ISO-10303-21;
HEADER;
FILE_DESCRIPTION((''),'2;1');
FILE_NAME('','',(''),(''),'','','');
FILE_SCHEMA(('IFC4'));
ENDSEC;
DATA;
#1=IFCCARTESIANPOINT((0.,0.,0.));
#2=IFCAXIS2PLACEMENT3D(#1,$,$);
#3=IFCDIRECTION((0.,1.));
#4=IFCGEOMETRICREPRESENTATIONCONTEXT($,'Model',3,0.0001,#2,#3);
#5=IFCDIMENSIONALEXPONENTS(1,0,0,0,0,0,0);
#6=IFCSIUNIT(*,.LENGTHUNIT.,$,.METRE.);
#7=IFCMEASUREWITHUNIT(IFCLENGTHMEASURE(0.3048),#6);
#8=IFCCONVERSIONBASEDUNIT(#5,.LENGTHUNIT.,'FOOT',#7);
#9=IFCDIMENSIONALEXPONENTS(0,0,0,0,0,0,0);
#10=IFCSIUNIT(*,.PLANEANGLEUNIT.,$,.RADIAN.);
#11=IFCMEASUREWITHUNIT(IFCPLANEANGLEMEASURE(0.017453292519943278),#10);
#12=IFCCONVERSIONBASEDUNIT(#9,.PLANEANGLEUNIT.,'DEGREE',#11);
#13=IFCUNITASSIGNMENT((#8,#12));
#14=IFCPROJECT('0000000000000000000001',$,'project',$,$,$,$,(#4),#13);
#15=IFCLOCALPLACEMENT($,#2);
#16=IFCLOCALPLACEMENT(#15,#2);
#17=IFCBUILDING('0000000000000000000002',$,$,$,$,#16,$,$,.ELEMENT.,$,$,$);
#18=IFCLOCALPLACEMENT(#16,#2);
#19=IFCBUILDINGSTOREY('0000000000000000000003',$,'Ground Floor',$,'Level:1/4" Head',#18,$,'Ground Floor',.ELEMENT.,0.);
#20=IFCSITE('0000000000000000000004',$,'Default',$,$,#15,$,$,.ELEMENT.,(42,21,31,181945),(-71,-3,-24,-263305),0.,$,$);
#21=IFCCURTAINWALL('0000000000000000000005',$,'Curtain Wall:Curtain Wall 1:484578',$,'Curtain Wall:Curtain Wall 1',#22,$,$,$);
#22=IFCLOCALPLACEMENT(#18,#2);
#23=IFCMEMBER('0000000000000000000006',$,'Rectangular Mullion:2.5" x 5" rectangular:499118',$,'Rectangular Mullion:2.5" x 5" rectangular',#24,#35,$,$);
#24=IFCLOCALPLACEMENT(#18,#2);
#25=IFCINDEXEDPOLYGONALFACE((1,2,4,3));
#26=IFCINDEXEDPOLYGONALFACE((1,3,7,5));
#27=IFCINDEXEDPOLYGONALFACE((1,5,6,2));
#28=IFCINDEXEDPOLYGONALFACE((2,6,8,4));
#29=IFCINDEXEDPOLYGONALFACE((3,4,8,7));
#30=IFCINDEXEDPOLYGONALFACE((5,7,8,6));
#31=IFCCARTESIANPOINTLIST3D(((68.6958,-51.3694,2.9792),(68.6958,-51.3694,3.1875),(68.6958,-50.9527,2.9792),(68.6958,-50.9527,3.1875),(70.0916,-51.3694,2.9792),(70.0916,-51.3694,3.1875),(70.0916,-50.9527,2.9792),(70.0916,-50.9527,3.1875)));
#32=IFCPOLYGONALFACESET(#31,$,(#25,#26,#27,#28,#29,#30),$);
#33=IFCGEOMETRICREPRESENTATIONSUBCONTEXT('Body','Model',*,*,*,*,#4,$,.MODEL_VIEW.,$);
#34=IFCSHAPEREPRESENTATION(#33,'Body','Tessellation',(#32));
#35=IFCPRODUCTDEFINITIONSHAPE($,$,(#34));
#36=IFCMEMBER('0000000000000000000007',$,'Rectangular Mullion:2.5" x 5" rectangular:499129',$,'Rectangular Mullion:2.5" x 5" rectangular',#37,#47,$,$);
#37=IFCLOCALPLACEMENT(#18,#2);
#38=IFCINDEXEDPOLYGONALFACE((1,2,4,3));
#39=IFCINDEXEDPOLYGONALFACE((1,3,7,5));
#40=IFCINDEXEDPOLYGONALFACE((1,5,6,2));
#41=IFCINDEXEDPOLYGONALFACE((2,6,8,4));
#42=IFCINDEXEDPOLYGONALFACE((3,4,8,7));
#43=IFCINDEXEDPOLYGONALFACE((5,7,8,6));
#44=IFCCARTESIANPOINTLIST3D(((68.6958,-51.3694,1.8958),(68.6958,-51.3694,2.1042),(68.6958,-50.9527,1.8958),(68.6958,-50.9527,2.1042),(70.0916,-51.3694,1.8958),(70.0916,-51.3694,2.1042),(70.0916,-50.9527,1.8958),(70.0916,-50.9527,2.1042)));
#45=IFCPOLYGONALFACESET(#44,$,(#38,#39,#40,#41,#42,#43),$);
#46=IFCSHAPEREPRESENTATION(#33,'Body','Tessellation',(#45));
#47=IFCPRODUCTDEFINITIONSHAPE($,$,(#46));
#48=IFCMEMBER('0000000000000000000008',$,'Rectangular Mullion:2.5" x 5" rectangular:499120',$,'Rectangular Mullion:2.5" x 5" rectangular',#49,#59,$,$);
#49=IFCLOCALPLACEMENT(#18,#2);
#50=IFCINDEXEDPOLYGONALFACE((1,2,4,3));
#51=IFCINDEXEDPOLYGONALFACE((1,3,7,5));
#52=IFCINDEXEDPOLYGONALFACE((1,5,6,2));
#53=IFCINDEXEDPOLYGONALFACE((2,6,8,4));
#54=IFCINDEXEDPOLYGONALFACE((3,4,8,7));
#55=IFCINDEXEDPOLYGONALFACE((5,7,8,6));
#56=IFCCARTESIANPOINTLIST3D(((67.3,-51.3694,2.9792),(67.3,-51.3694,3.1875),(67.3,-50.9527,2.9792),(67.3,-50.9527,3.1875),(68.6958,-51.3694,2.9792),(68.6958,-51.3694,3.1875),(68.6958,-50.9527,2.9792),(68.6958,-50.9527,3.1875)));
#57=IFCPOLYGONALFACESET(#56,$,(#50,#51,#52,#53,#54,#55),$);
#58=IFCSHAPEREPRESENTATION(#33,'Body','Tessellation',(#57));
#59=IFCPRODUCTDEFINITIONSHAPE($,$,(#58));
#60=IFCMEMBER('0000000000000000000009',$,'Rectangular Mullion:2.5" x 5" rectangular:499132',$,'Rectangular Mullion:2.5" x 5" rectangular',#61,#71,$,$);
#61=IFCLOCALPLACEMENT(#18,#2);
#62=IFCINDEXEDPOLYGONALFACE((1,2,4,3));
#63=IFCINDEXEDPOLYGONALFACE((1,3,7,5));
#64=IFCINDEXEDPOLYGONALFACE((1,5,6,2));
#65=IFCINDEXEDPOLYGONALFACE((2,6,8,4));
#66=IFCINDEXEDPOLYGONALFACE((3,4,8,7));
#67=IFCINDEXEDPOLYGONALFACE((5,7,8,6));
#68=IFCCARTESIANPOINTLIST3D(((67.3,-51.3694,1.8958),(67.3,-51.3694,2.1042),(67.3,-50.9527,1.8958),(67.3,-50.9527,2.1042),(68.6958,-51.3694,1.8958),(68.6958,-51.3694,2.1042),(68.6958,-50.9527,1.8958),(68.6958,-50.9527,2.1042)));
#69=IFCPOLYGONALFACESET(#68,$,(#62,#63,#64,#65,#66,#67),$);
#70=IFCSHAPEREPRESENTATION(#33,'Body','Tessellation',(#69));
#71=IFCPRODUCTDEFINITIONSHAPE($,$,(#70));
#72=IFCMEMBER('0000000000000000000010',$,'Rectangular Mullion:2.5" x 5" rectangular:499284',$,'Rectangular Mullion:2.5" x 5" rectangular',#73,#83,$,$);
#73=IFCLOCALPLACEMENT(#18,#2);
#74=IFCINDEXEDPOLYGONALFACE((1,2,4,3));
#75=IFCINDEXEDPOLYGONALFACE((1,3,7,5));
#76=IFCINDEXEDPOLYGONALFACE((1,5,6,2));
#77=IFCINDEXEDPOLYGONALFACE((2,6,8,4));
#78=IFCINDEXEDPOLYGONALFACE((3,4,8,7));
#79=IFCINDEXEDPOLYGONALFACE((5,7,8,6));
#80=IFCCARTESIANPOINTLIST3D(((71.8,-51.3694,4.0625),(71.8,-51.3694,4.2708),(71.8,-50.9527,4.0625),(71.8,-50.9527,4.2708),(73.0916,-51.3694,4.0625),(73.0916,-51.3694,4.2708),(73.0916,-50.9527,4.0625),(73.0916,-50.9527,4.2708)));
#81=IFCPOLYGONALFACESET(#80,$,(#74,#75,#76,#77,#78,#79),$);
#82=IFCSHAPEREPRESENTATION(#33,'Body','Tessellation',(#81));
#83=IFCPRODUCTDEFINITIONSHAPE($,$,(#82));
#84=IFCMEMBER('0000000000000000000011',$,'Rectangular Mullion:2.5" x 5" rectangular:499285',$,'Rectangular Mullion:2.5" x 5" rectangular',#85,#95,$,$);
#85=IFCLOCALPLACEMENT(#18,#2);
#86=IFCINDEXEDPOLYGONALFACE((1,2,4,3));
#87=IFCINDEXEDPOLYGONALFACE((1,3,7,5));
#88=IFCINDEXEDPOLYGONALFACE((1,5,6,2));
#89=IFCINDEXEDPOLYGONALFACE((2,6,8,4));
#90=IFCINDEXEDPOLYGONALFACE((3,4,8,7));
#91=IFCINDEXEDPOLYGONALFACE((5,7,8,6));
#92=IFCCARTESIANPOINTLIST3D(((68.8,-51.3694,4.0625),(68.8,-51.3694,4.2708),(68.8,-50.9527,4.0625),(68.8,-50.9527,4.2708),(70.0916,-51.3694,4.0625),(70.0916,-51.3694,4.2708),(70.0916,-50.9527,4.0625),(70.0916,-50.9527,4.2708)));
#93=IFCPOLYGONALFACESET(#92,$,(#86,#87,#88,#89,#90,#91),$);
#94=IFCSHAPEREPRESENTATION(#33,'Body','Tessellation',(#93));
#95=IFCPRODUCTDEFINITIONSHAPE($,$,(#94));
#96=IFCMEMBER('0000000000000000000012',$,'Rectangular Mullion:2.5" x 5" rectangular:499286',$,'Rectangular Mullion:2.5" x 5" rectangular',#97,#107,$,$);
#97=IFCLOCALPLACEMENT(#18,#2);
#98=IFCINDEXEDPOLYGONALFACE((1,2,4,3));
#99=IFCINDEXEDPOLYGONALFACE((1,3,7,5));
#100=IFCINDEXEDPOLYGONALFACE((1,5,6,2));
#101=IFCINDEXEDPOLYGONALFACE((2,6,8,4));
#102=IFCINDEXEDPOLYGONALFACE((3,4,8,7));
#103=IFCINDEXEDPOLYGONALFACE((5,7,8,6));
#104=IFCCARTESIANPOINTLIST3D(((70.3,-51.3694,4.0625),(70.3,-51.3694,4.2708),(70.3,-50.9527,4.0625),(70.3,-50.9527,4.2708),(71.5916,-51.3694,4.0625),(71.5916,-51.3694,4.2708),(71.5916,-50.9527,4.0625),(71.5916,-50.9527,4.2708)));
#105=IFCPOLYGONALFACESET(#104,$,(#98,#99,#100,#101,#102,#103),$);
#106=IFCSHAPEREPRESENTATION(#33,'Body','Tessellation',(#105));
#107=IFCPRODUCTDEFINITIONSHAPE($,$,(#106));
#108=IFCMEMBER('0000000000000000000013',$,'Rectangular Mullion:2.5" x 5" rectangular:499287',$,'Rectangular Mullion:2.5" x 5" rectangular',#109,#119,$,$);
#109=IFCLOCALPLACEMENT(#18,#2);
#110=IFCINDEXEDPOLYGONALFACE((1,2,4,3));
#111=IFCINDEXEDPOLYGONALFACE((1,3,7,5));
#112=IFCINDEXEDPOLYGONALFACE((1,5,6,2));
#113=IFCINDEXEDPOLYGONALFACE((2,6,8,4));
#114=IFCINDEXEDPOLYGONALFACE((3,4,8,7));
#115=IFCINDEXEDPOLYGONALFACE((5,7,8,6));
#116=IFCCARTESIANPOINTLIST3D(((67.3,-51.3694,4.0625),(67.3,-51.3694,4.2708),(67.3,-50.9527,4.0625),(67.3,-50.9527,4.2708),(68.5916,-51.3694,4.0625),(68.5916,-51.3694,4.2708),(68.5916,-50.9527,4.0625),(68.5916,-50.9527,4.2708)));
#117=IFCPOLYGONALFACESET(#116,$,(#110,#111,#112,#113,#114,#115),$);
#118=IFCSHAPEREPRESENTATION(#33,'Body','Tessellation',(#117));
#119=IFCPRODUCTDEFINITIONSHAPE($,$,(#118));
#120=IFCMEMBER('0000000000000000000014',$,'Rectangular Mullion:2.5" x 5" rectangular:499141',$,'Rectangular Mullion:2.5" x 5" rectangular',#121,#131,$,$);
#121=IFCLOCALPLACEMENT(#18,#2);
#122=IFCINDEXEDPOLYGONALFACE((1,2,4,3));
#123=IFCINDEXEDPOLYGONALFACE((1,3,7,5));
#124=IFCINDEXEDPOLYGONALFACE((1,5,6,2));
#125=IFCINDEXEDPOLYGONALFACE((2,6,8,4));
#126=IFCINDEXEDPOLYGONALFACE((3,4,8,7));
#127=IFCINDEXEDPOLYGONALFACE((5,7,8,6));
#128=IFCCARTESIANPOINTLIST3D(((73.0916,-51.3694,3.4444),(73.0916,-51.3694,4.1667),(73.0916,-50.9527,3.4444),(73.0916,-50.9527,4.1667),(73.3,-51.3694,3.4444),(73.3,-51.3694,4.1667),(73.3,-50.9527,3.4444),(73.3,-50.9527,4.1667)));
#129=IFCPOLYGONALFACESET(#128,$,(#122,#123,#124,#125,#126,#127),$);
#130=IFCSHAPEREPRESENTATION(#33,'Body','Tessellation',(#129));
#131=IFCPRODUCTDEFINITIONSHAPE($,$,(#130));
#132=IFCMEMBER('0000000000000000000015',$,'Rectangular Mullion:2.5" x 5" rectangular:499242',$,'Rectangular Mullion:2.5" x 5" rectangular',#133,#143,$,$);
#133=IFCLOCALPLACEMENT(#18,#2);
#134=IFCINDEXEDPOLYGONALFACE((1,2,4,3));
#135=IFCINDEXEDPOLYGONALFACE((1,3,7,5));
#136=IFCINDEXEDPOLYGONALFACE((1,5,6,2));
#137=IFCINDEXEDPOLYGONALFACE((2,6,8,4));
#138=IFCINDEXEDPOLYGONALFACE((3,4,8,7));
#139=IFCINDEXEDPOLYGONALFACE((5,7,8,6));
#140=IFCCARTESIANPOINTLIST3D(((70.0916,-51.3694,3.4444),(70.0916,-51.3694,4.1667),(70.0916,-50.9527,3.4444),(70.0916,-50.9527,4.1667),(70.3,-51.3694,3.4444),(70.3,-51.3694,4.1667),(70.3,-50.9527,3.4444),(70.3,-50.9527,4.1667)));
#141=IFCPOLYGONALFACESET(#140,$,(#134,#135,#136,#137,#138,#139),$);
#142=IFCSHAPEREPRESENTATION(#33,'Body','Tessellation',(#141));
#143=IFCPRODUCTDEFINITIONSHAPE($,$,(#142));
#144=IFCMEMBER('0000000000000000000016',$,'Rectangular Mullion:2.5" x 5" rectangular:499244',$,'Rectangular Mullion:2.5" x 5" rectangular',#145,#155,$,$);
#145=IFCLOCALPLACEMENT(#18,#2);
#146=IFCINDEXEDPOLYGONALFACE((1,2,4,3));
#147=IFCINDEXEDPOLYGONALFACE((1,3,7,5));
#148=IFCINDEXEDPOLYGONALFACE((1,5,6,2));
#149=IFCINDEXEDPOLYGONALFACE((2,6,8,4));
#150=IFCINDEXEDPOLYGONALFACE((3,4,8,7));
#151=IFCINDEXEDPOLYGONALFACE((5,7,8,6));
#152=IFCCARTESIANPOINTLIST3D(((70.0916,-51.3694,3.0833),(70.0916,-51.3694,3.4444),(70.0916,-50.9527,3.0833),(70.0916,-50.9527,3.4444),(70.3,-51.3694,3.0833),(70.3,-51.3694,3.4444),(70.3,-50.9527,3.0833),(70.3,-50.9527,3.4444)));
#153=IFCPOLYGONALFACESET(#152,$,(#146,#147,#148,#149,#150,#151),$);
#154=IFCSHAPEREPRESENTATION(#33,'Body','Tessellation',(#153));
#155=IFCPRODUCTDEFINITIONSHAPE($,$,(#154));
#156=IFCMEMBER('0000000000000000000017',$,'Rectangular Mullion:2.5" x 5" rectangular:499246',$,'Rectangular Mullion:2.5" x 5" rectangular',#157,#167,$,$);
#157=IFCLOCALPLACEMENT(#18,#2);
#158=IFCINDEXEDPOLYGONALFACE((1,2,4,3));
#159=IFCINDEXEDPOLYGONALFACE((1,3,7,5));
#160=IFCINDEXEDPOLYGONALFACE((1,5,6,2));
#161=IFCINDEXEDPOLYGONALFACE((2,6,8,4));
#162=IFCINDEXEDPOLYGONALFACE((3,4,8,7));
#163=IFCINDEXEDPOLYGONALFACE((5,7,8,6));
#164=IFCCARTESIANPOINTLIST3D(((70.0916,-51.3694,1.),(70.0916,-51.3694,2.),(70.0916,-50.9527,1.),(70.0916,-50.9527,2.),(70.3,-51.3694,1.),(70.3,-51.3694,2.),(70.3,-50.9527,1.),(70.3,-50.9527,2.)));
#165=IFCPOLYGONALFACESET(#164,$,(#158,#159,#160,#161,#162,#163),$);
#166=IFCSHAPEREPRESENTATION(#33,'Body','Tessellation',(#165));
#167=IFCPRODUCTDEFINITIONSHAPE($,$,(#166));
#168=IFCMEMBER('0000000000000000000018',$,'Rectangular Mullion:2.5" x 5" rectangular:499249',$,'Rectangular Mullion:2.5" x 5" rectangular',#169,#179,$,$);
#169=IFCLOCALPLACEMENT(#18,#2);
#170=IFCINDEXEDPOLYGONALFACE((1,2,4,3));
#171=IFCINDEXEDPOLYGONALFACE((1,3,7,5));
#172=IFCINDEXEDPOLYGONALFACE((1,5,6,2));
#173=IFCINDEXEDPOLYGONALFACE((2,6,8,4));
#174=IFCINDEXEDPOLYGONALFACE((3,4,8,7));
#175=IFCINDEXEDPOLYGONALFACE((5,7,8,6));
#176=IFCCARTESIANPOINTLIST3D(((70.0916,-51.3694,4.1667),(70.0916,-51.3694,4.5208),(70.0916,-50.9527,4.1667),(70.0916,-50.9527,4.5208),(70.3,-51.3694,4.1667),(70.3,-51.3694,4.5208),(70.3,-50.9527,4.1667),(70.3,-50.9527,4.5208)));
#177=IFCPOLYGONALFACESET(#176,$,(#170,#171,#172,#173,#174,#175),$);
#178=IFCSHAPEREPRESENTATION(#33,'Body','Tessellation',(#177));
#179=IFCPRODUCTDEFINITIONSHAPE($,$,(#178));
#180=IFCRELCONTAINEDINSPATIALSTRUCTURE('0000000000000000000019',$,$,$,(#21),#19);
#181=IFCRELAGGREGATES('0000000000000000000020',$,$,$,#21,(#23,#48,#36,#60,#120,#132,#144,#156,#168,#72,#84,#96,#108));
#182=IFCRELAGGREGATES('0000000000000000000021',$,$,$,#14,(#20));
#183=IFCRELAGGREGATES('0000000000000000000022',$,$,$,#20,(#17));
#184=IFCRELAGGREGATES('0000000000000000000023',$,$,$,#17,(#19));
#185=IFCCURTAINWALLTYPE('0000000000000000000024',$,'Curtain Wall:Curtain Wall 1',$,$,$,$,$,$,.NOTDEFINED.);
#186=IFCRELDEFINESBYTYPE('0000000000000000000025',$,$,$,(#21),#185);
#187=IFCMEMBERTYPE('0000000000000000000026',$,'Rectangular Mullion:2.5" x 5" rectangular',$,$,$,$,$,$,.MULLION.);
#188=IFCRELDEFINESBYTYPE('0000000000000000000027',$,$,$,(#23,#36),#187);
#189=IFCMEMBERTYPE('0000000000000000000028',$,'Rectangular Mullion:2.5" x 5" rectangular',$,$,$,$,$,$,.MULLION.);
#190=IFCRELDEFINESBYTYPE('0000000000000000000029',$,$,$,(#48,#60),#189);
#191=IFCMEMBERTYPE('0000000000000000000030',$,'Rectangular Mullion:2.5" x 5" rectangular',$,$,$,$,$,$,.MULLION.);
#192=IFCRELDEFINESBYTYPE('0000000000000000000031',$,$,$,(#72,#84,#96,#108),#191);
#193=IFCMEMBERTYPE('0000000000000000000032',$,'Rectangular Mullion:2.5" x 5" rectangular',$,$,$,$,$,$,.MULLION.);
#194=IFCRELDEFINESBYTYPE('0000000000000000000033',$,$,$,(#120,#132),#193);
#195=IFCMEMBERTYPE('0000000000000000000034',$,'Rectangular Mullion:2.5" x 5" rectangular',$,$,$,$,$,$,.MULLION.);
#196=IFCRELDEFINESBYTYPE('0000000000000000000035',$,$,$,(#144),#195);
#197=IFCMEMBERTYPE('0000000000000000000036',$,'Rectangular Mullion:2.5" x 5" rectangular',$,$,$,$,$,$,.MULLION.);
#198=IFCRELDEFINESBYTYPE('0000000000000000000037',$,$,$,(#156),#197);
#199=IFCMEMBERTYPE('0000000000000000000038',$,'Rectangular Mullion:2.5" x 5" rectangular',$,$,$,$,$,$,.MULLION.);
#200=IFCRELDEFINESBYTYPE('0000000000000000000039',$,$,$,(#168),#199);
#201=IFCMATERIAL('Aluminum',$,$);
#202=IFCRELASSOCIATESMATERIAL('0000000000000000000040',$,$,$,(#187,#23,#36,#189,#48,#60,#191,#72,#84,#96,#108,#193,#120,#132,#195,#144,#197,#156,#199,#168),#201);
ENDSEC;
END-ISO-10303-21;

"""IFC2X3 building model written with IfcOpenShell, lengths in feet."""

from ifc_helpers import new_model, entity, si_unit, converted_unit, direction, frame, origin, origin_2d_with_axis, place, context, subcontext, project, spatial, rectangle, extrude, source, transform, mapped, material, type_object, type_shapes, element, aggregate, save


model = new_model("IFC2X3")

# Units and contexts
model_context = context("Model", 3, precision=0.0001, world=origin(), true_north=direction((0.0, 1.0)))
body_context = subcontext(model_context, "Body", "Model", "MODEL_VIEW")
ifc_project = project(units=[converted_unit("LENGTHUNIT", "FOOT", entity("IfcLengthMeasure", 0.3048), si_unit("LENGTHUNIT", "METRE"), dimensions=[1, 0, 0, 0, 0, 0, 0]), converted_unit("PLANEANGLEUNIT", "DEGREE", entity("IfcPlaneAngleMeasure", 0.017453292519943278), si_unit("PLANEANGLEUNIT", "RADIAN"), dimensions=[0, 0, 0, 0, 0, 0, 0])], contexts=[model_context])

# Site, building, storey
site_placement = place(None, origin())
site = spatial("IfcSite", under=ifc_project, at=site_placement, Name="Default", CompositionType="ELEMENT", RefLatitude=(42, 21, 31, 181945), RefLongitude=(-71, -3, -24, -263305), RefElevation=0.0)
building_placement = place(site_placement, origin())
building = spatial("IfcBuilding", under=site, at=building_placement, CompositionType="ELEMENT")
storey_placement = place(building_placement, origin())
storey = spatial("IfcBuildingStorey", under=building, at=storey_placement, Name="Ground Floor", ObjectType="Level:1/4\" Head", LongName="Ground Floor", CompositionType="ELEMENT", Elevation=0.0)

# Curtain wall, members
curtain_wall_type = type_object("IfcCurtainWallType", Name="Curtain Wall:Curtain Wall 1", PredefinedType="NOTDEFINED")
curtain_wall_placement = place(storey_placement, origin())
curtain_wall = element("IfcCurtainWall", 1, at=curtain_wall_placement, inside=storey, type_object=curtain_wall_type, Name="Curtain Wall:Curtain Wall 1:484578", ObjectType="Curtain Wall:Curtain Wall 1")
ifc_material_1 = material(Name="Aluminum")
member_type_1 = type_object("IfcMemberType", Name="Rectangular Mullion:2.5\" x 5\" rectangular", PredefinedType="MULLION", material=ifc_material_1)
shared_shape_1 = source(origin(), body_context, "Body", "SweptSolid", [
    extrude(rectangle(XDim=0.2083, YDim=0.4167, at=origin_2d_with_axis()), frame((0.0, 0.0, -1.3958), z_axis=(0.0, 0.0, 1.0), x_axis=(-1.0, 0.0, 0.0)), (0.0, 0.0, 1.0), 1.3958),
])
type_shapes(member_type_1, [shared_shape_1])
member_1_placement = place(curtain_wall_placement, frame((70.0916, -51.161, 3.0833), z_axis=(1.0, 0.0, 0.0), x_axis=(0.0, 0.0, 1.0)))
member_1 = element("IfcMember", 2, at=member_1_placement, type_object=member_type_1, material=ifc_material_1, Name="Rectangular Mullion:2.5\" x 5\" rectangular:499118", ObjectType="Rectangular Mullion:2.5\" x 5\" rectangular", context=body_context, shape_type="MappedRepresentation", body=[
    mapped(shared_shape_1, transform((0.0, 0.0, 0.0), scale=1.0)),
])
member_2_placement = place(curtain_wall_placement, frame((70.0916, -51.161, 2.0), z_axis=(1.0, 0.0, 0.0), x_axis=(0.0, 0.0, 1.0)))
member_2 = element("IfcMember", 3, at=member_2_placement, type_object=member_type_1, material=ifc_material_1, Name="Rectangular Mullion:2.5\" x 5\" rectangular:499129", ObjectType="Rectangular Mullion:2.5\" x 5\" rectangular", context=body_context, shape_type="MappedRepresentation", body=[
    mapped(shared_shape_1, transform((0.0, 0.0, 0.0), scale=1.0)),
])
member_type_2 = type_object("IfcMemberType", Name="Rectangular Mullion:2.5\" x 5\" rectangular", PredefinedType="MULLION", material=ifc_material_1)
shared_shape_2 = source(origin(), body_context, "Body", "SweptSolid", [
    extrude(rectangle(XDim=0.2083, YDim=0.4167, at=origin_2d_with_axis()), frame((0.0, 0.0, -1.3958), z_axis=(0.0, 0.0, 1.0), x_axis=(-1.0, 0.0, 0.0)), (0.0, 0.0, 1.0), 1.3958),
])
type_shapes(member_type_2, [shared_shape_2])
member_3_placement = place(curtain_wall_placement, frame((68.6958, -51.161, 3.0833), z_axis=(1.0, 0.0, 0.0), x_axis=(0.0, 0.0, 1.0)))
member_3 = element("IfcMember", 4, at=member_3_placement, type_object=member_type_2, material=ifc_material_1, Name="Rectangular Mullion:2.5\" x 5\" rectangular:499120", ObjectType="Rectangular Mullion:2.5\" x 5\" rectangular", context=body_context, shape_type="MappedRepresentation", body=[
    mapped(shared_shape_2, transform((0.0, 0.0, 0.0), scale=1.0)),
])
member_4_placement = place(curtain_wall_placement, frame((68.6958, -51.161, 2.0), z_axis=(1.0, 0.0, 0.0), x_axis=(0.0, 0.0, 1.0)))
member_4 = element("IfcMember", 5, at=member_4_placement, type_object=member_type_2, material=ifc_material_1, Name="Rectangular Mullion:2.5\" x 5\" rectangular:499132", ObjectType="Rectangular Mullion:2.5\" x 5\" rectangular", context=body_context, shape_type="MappedRepresentation", body=[
    mapped(shared_shape_2, transform((0.0, 0.0, 0.0), scale=1.0)),
])
member_type_3 = type_object("IfcMemberType", Name="Rectangular Mullion:2.5\" x 5\" rectangular", PredefinedType="MULLION", material=ifc_material_1)
shared_shape_3 = source(origin(), body_context, "Body", "SweptSolid", [
    extrude(rectangle(XDim=0.2083, YDim=0.4167, at=origin_2d_with_axis()), frame((0.0, 0.0, -1.2917), z_axis=(0.0, 0.0, 1.0), x_axis=(-1.0, 0.0, 0.0)), (0.0, 0.0, 1.0), 1.2917),
])
type_shapes(member_type_3, [shared_shape_3])
member_5_placement = place(curtain_wall_placement, frame((73.0916, -51.161, 4.1667), z_axis=(1.0, 0.0, 0.0), x_axis=(0.0, 0.0, 1.0)))
member_5 = element("IfcMember", 6, at=member_5_placement, type_object=member_type_3, material=ifc_material_1, Name="Rectangular Mullion:2.5\" x 5\" rectangular:499284", ObjectType="Rectangular Mullion:2.5\" x 5\" rectangular", context=body_context, shape_type="MappedRepresentation", body=[
    mapped(shared_shape_3, transform((0.0, 0.0, 0.0), scale=1.0)),
])
member_6_placement = place(curtain_wall_placement, frame((70.0916, -51.161, 4.1667), z_axis=(1.0, 0.0, 0.0), x_axis=(0.0, 0.0, 1.0)))
member_6 = element("IfcMember", 7, at=member_6_placement, type_object=member_type_3, material=ifc_material_1, Name="Rectangular Mullion:2.5\" x 5\" rectangular:499285", ObjectType="Rectangular Mullion:2.5\" x 5\" rectangular", context=body_context, shape_type="MappedRepresentation", body=[
    mapped(shared_shape_3, transform((0.0, 0.0, 0.0), scale=1.0)),
])
member_7_placement = place(curtain_wall_placement, frame((71.5916, -51.161, 4.1667), z_axis=(1.0, 0.0, 0.0), x_axis=(0.0, 0.0, 1.0)))
member_7 = element("IfcMember", 8, at=member_7_placement, type_object=member_type_3, material=ifc_material_1, Name="Rectangular Mullion:2.5\" x 5\" rectangular:499286", ObjectType="Rectangular Mullion:2.5\" x 5\" rectangular", context=body_context, shape_type="MappedRepresentation", body=[
    mapped(shared_shape_3, transform((0.0, 0.0, 0.0), scale=1.0)),
])
member_8_placement = place(curtain_wall_placement, frame((68.5916, -51.161, 4.1667), z_axis=(1.0, 0.0, 0.0), x_axis=(0.0, 0.0, 1.0)))
member_8 = element("IfcMember", 9, at=member_8_placement, type_object=member_type_3, material=ifc_material_1, Name="Rectangular Mullion:2.5\" x 5\" rectangular:499287", ObjectType="Rectangular Mullion:2.5\" x 5\" rectangular", context=body_context, shape_type="MappedRepresentation", body=[
    mapped(shared_shape_3, transform((0.0, 0.0, 0.0), scale=1.0)),
])
member_type_4 = type_object("IfcMemberType", Name="Rectangular Mullion:2.5\" x 5\" rectangular", PredefinedType="MULLION", material=ifc_material_1)
shared_shape_4 = source(origin(), body_context, "Body", "SweptSolid", [
    extrude(rectangle(XDim=0.2083, YDim=0.4167, at=origin_2d_with_axis()), frame((0.0, 0.0, -0.7222), z_axis=(0.0, 0.0, 1.0), x_axis=(-1.0, 0.0, 0.0)), (0.0, 0.0, 1.0), 0.7222),
])
type_shapes(member_type_4, [shared_shape_4])
member_9_placement = place(curtain_wall_placement, frame((73.1958, -51.161, 3.4444), z_axis=(0.0, 0.0, -1.0), x_axis=(1.0, 0.0, 0.0)))
member_9 = element("IfcMember", 10, at=member_9_placement, type_object=member_type_4, material=ifc_material_1, Name="Rectangular Mullion:2.5\" x 5\" rectangular:499141", ObjectType="Rectangular Mullion:2.5\" x 5\" rectangular", context=body_context, shape_type="MappedRepresentation", body=[
    mapped(shared_shape_4, transform((0.0, 0.0, 0.0), scale=1.0)),
])
member_10_placement = place(curtain_wall_placement, frame((70.1958, -51.161, 3.4444), z_axis=(0.0, 0.0, -1.0), x_axis=(1.0, 0.0, 0.0)))
member_10 = element("IfcMember", 11, at=member_10_placement, type_object=member_type_4, material=ifc_material_1, Name="Rectangular Mullion:2.5\" x 5\" rectangular:499242", ObjectType="Rectangular Mullion:2.5\" x 5\" rectangular", context=body_context, shape_type="MappedRepresentation", body=[
    mapped(shared_shape_4, transform((0.0, 0.0, 0.0), scale=1.0)),
])
member_type_5 = type_object("IfcMemberType", Name="Rectangular Mullion:2.5\" x 5\" rectangular", PredefinedType="MULLION", material=ifc_material_1)
shared_shape_5 = source(origin(), body_context, "Body", "SweptSolid", [
    extrude(rectangle(XDim=0.2083, YDim=0.4167, at=origin_2d_with_axis()), frame((0.0, 0.0, -0.3611), z_axis=(0.0, 0.0, 1.0), x_axis=(-1.0, 0.0, 0.0)), (0.0, 0.0, 1.0), 0.3611),
])
type_shapes(member_type_5, [shared_shape_5])
member_11_placement = place(curtain_wall_placement, frame((70.1958, -51.161, 3.0833), z_axis=(0.0, 0.0, -1.0), x_axis=(1.0, 0.0, 0.0)))
member_11 = element("IfcMember", 12, at=member_11_placement, type_object=member_type_5, material=ifc_material_1, Name="Rectangular Mullion:2.5\" x 5\" rectangular:499244", ObjectType="Rectangular Mullion:2.5\" x 5\" rectangular", context=body_context, shape_type="MappedRepresentation", body=[
    mapped(shared_shape_5, transform((0.0, 0.0, 0.0), scale=1.0)),
])
member_type_6 = type_object("IfcMemberType", Name="Rectangular Mullion:2.5\" x 5\" rectangular", PredefinedType="MULLION", material=ifc_material_1)
shared_shape_6 = source(origin(), body_context, "Body", "SweptSolid", [
    extrude(rectangle(XDim=0.2083, YDim=0.4167, at=origin_2d_with_axis()), frame((0.0, 0.0, -1.0), z_axis=(0.0, 0.0, 1.0), x_axis=(-1.0, 0.0, 0.0)), (0.0, 0.0, 1.0), 1.0),
])
type_shapes(member_type_6, [shared_shape_6])
member_12_placement = place(curtain_wall_placement, frame((70.1958, -51.161, 1.0), z_axis=(0.0, 0.0, -1.0), x_axis=(1.0, 0.0, 0.0)))
member_12 = element("IfcMember", 13, at=member_12_placement, type_object=member_type_6, material=ifc_material_1, Name="Rectangular Mullion:2.5\" x 5\" rectangular:499246", ObjectType="Rectangular Mullion:2.5\" x 5\" rectangular", context=body_context, shape_type="MappedRepresentation", body=[
    mapped(shared_shape_6, transform((0.0, 0.0, 0.0), scale=1.0)),
])
member_type_7 = type_object("IfcMemberType", Name="Rectangular Mullion:2.5\" x 5\" rectangular", PredefinedType="MULLION", material=ifc_material_1)
shared_shape_7 = source(origin(), body_context, "Body", "SweptSolid", [
    extrude(rectangle(XDim=0.2083, YDim=0.4167, at=origin_2d_with_axis()), frame((0.0, 0.0, -0.3542), z_axis=(0.0, 0.0, 1.0), x_axis=(-1.0, 0.0, 0.0)), (0.0, 0.0, 1.0), 0.3542),
])
type_shapes(member_type_7, [shared_shape_7])
member_13_placement = place(curtain_wall_placement, frame((70.1958, -51.161, 4.1667), z_axis=(0.0, 0.0, -1.0), x_axis=(1.0, 0.0, 0.0)))
member_13 = element("IfcMember", 14, at=member_13_placement, type_object=member_type_7, material=ifc_material_1, Name="Rectangular Mullion:2.5\" x 5\" rectangular:499249", ObjectType="Rectangular Mullion:2.5\" x 5\" rectangular", context=body_context, shape_type="MappedRepresentation", body=[
    mapped(shared_shape_7, transform((0.0, 0.0, 0.0), scale=1.0)),
])
aggregate(curtain_wall, [member_1, member_3, member_2, member_4, member_9, member_10, member_11, member_12, member_13, member_5, member_6, member_7, member_8])

save(model, "model.ifc")
